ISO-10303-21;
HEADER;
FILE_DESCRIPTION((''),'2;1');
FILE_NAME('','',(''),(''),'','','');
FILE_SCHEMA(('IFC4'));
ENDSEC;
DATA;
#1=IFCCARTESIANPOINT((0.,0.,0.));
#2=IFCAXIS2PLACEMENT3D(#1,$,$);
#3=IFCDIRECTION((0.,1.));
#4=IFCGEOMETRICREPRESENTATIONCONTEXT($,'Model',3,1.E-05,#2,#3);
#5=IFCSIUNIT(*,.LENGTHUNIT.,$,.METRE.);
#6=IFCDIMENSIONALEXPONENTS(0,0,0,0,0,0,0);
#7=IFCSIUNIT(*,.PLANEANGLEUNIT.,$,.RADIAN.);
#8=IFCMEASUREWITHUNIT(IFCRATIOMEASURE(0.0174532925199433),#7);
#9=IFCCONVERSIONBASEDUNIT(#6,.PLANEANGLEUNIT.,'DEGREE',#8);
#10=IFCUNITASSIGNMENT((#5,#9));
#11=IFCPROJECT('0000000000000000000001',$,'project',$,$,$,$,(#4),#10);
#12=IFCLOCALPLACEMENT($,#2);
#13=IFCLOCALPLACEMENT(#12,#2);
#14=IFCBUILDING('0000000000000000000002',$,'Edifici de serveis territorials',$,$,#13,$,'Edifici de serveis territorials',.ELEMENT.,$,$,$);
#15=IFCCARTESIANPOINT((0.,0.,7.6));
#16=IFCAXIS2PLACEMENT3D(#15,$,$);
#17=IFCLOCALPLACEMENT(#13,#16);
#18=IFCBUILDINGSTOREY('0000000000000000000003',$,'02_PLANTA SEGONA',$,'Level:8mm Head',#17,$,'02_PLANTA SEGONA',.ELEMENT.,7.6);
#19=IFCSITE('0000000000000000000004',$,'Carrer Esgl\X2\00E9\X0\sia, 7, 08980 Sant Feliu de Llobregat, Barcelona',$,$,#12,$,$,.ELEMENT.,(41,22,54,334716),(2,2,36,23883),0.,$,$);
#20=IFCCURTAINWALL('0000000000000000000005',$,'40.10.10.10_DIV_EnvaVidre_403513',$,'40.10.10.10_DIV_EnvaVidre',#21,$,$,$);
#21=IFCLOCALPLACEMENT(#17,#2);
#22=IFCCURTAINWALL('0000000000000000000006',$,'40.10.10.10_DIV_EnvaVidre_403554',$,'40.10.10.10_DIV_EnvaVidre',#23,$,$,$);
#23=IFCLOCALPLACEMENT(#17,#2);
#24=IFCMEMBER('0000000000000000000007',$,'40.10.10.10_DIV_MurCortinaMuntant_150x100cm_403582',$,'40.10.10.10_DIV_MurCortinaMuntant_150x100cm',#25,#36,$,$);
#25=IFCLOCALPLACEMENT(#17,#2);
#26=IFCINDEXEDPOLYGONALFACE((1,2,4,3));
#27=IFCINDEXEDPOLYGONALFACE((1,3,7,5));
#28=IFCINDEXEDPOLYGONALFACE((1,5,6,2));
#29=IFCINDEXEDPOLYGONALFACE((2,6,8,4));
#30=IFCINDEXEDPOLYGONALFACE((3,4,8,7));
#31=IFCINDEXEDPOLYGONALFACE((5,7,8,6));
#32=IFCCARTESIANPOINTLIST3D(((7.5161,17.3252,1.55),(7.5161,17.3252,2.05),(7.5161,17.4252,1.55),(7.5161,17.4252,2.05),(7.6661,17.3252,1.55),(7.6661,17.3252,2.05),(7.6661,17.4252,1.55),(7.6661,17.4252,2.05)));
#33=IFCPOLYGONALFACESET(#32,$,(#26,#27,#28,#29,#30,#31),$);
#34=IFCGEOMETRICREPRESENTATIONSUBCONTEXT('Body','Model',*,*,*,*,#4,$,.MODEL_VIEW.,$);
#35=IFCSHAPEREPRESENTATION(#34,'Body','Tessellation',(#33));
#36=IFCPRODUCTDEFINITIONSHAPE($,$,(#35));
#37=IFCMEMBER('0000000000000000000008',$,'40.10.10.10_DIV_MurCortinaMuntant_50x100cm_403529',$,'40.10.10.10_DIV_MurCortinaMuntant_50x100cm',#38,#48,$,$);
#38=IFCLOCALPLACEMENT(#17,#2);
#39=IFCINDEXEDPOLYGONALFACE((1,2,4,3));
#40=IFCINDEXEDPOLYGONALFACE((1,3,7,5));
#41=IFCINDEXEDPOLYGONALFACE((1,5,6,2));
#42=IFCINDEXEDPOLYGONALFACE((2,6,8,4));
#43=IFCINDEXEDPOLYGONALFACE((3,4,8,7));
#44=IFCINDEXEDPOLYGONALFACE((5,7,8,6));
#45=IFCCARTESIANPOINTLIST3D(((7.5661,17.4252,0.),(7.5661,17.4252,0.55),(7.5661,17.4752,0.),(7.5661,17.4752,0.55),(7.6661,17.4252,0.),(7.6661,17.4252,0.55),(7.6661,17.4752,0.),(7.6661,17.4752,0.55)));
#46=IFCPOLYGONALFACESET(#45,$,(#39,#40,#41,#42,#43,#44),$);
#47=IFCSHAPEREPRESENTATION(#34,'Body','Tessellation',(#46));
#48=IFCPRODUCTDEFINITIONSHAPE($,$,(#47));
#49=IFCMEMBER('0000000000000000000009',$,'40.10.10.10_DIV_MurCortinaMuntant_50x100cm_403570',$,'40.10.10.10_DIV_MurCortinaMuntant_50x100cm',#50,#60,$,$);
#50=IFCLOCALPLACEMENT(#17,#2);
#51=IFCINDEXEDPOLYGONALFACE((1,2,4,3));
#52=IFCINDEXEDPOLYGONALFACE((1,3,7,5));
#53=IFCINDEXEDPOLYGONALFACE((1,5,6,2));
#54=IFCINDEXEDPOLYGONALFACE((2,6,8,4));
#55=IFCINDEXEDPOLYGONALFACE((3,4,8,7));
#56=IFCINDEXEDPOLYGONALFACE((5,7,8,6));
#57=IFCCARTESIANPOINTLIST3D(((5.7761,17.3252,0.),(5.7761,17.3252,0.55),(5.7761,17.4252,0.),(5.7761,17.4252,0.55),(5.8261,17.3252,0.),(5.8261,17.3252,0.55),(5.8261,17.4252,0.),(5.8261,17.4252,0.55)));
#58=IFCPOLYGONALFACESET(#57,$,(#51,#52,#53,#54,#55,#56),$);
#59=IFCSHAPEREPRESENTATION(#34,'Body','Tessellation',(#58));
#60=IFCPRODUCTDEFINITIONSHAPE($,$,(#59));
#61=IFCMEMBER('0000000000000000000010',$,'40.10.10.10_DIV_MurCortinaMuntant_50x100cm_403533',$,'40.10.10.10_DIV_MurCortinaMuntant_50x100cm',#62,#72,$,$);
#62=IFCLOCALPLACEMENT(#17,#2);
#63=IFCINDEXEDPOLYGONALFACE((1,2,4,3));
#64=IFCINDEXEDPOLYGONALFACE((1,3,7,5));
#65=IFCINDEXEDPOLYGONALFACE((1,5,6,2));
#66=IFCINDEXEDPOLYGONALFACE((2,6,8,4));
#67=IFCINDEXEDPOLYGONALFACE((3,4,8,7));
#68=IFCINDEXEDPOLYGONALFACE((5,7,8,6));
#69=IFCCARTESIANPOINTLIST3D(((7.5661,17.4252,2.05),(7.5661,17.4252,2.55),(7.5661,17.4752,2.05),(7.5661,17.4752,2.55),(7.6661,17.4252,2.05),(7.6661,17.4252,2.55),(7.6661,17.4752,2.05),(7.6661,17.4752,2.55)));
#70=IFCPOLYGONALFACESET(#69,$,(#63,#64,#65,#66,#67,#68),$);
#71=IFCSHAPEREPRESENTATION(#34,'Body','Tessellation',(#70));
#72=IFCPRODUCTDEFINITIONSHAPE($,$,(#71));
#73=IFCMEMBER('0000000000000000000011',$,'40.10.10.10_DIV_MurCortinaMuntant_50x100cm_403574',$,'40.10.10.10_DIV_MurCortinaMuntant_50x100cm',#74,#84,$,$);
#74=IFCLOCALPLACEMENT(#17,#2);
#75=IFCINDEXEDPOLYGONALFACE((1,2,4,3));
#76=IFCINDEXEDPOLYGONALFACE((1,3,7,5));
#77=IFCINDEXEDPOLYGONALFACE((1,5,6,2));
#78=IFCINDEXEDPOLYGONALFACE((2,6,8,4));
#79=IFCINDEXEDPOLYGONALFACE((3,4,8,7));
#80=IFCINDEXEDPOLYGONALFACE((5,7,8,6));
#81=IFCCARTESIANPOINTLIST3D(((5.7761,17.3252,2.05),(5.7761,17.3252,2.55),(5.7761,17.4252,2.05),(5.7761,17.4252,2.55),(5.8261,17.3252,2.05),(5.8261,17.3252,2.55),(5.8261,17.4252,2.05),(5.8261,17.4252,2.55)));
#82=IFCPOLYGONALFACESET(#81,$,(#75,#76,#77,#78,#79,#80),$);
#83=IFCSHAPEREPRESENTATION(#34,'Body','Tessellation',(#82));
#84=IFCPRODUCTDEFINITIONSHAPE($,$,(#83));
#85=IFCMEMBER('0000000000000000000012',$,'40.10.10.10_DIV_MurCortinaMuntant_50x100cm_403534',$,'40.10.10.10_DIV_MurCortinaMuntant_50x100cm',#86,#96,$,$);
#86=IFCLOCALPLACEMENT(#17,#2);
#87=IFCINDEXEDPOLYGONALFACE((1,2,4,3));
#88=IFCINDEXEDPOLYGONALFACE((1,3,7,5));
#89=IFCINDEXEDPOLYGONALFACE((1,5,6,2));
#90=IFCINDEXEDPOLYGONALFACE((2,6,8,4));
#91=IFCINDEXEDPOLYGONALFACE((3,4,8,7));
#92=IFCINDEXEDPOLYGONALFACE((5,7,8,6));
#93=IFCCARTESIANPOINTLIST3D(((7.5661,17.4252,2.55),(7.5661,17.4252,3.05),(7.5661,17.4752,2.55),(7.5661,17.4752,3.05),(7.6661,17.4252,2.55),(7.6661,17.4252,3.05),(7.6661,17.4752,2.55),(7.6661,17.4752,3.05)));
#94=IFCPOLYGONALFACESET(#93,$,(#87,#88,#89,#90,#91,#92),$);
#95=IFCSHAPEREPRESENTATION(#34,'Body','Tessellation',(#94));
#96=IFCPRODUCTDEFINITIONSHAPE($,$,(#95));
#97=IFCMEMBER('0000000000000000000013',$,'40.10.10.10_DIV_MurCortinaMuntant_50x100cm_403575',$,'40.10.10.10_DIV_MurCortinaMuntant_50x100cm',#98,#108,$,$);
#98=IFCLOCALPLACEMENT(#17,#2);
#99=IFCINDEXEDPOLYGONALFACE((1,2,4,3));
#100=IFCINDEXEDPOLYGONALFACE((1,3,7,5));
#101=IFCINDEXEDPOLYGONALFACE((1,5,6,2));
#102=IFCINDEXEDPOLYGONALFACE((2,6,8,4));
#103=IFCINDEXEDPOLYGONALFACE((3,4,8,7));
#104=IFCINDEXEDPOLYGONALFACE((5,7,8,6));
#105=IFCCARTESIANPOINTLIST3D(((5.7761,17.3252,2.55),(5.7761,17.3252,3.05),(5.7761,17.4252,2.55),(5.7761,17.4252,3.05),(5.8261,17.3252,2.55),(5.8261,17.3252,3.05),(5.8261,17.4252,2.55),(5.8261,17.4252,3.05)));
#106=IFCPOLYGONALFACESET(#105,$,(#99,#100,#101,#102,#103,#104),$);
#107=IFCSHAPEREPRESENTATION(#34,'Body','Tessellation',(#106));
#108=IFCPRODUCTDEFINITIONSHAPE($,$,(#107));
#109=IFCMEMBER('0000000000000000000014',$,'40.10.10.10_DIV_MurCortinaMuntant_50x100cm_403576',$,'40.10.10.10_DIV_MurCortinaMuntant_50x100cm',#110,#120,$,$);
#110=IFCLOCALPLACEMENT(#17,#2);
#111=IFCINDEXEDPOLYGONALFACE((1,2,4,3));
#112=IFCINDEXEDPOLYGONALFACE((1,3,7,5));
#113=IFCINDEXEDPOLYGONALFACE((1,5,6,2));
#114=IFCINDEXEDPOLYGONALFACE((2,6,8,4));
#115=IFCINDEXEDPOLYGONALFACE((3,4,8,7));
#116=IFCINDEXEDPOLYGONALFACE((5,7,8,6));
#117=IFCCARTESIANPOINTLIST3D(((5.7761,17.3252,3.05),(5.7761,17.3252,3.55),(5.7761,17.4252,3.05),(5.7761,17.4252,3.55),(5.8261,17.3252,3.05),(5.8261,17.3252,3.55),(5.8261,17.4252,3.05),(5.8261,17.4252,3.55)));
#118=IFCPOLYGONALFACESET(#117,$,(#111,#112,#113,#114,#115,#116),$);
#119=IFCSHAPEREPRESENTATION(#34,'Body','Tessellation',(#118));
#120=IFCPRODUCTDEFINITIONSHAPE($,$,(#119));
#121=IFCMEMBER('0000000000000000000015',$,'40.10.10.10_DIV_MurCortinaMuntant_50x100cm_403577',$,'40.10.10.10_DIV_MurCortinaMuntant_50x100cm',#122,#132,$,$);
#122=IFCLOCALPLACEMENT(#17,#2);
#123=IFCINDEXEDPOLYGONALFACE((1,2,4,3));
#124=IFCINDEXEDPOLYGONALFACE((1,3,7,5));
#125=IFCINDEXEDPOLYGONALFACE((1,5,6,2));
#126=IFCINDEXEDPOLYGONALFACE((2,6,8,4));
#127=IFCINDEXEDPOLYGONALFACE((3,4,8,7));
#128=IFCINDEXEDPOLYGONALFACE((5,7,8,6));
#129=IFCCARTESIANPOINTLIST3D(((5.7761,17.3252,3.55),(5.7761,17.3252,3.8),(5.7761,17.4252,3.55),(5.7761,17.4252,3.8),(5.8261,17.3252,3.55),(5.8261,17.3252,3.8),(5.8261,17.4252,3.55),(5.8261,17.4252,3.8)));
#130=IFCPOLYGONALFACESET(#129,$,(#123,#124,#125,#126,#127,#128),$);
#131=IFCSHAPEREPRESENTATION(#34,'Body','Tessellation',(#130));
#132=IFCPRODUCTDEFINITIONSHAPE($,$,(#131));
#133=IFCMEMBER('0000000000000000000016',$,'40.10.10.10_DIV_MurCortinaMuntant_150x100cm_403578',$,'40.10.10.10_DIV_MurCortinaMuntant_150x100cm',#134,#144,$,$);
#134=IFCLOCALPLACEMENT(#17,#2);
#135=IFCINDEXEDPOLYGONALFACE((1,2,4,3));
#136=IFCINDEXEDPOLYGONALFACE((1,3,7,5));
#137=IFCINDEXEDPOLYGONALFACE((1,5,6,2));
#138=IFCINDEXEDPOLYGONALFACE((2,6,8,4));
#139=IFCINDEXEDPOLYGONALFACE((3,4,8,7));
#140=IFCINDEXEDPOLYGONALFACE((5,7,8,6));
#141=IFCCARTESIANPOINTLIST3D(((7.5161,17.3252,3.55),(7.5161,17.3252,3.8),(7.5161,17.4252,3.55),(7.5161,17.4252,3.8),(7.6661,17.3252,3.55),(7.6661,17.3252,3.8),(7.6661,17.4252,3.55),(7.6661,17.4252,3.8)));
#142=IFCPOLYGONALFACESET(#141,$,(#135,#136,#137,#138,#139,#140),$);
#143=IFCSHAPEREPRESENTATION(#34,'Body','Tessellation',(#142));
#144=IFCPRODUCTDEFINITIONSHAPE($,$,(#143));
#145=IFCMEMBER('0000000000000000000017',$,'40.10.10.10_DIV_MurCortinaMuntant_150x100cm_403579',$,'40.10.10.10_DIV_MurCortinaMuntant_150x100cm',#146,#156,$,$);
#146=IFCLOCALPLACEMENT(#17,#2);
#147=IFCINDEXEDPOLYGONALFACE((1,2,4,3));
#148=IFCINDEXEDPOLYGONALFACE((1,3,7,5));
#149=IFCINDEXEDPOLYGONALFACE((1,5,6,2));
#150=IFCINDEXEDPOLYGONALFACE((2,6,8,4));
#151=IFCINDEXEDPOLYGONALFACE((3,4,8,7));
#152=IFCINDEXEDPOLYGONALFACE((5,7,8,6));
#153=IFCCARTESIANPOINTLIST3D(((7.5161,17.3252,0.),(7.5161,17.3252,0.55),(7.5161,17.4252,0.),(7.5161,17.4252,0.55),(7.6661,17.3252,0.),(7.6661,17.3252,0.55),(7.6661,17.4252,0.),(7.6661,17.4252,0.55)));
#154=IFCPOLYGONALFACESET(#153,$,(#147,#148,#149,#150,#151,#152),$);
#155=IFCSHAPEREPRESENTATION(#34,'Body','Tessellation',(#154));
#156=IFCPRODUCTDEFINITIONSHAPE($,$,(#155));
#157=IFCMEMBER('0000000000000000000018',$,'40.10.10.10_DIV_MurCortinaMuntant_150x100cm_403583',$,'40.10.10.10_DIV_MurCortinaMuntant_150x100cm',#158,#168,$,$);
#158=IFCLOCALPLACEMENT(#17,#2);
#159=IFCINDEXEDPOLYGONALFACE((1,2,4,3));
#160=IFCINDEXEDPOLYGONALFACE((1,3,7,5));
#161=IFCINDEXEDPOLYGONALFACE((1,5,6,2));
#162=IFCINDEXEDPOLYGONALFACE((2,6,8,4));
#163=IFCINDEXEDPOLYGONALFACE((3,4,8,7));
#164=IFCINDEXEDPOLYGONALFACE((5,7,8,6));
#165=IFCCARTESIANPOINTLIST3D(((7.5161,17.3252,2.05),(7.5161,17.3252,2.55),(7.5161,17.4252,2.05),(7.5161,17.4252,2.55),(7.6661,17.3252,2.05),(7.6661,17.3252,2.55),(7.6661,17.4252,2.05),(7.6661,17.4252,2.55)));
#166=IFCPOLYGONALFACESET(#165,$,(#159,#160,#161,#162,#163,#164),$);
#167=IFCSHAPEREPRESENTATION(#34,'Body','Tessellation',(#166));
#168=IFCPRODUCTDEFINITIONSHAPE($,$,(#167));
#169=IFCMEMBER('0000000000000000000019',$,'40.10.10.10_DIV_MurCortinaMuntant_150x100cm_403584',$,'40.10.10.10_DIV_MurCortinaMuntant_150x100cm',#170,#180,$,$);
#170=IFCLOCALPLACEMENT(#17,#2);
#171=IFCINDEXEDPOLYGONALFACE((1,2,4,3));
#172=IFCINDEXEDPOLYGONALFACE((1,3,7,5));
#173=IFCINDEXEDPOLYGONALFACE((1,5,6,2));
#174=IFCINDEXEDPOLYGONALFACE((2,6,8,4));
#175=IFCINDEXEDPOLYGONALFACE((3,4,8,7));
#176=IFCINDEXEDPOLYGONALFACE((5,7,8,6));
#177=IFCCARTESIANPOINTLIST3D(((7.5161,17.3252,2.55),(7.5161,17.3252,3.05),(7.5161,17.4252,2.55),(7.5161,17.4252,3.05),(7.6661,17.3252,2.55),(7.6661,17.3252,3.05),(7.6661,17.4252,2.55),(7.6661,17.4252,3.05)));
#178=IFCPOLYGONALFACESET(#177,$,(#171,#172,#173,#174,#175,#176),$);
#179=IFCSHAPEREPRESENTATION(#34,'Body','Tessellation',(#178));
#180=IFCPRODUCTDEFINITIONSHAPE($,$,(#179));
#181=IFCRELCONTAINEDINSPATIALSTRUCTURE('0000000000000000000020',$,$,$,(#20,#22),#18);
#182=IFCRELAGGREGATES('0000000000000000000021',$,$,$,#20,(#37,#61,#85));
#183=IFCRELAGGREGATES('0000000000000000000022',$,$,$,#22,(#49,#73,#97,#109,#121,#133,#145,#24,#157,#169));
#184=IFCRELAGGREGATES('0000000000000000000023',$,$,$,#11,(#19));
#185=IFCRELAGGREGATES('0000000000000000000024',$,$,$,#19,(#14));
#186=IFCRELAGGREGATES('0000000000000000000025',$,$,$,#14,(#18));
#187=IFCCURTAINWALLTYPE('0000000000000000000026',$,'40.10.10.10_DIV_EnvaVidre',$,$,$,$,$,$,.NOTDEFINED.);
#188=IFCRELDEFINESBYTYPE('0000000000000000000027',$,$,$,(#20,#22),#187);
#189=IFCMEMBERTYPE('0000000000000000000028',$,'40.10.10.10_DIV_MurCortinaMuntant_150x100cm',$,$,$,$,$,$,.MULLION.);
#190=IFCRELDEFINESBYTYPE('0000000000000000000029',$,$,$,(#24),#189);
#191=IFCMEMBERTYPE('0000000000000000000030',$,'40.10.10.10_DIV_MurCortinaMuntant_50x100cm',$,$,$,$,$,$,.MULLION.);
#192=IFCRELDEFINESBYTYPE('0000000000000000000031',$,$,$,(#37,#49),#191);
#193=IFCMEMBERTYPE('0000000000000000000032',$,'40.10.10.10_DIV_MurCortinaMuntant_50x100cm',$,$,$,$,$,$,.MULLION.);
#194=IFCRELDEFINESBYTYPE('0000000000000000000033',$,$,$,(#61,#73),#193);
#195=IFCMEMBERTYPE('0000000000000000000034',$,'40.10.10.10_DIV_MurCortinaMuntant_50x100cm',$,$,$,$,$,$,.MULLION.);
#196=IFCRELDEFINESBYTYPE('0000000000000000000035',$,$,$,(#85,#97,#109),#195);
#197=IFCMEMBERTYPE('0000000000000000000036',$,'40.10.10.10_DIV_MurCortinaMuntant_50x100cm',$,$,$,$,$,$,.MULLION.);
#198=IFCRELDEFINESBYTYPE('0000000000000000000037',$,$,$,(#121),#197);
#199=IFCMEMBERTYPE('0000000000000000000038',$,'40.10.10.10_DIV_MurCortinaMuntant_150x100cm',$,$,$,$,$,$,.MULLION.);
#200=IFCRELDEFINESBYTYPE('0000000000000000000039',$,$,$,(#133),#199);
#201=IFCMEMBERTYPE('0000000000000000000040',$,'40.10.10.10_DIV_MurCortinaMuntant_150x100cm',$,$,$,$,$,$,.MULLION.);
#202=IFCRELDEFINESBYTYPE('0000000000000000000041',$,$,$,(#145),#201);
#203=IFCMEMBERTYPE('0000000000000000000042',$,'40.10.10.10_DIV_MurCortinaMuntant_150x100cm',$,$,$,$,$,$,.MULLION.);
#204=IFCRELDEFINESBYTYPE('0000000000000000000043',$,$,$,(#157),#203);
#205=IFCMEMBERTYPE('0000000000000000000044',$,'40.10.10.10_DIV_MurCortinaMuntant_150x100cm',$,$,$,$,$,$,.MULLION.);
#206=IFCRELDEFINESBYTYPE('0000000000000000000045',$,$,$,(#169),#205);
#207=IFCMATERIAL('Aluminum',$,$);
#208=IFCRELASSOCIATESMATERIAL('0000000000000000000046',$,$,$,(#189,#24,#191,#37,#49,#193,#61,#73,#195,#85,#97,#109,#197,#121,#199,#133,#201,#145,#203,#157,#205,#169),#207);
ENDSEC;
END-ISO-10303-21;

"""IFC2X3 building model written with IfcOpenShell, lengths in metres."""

from ifc_helpers import new_model, entity, si_unit, converted_unit, direction, frame, origin, origin_2d_with_axis, place, context, subcontext, project, spatial, rectangle, extrude, source, transform, mapped, material, type_object, type_shapes, element, aggregate, save


model = new_model("IFC2X3")

# Units and contexts
model_context = context("Model", 3, precision=1e-05, world=origin(), true_north=direction((0.0, 1.0)))
body_context = subcontext(model_context, "Body", "Model", "MODEL_VIEW")
ifc_project = project(units=[si_unit("LENGTHUNIT", "METRE"), converted_unit("PLANEANGLEUNIT", "DEGREE", entity("IfcRatioMeasure", 0.0174532925199433), si_unit("PLANEANGLEUNIT", "RADIAN"), dimensions=[0, 0, 0, 0, 0, 0, 0])], contexts=[model_context])

# Site, building, storey
site_placement = place(None, origin())
site = spatial("IfcSite", under=ifc_project, at=site_placement, Name="Carrer Església, 7, 08980 Sant Feliu de Llobregat, Barcelona", CompositionType="ELEMENT", RefLatitude=(41, 22, 54, 334716), RefLongitude=(2, 2, 36, 23883), RefElevation=0.0)
building_placement = place(site_placement, origin())
building = spatial("IfcBuilding", under=site, at=building_placement, Name="Edifici de serveis territorials", LongName="Edifici de serveis territorials", CompositionType="ELEMENT")
storey_placement = place(building_placement, frame((0.0, 0.0, 7.6)))
storey = spatial("IfcBuildingStorey", under=building, at=storey_placement, Name="02_PLANTA SEGONA", ObjectType="Level:8mm Head", LongName="02_PLANTA SEGONA", CompositionType="ELEMENT", Elevation=7.6)

# Curtain walls, member
curtain_wall_type = type_object("IfcCurtainWallType", Name="40.10.10.10_DIV_EnvaVidre", PredefinedType="NOTDEFINED")
curtain_wall_1_placement = place(storey_placement, frame((0.0, 0.0, -7.6)))
curtain_wall_1 = element("IfcCurtainWall", 1, at=curtain_wall_1_placement, inside=storey, type_object=curtain_wall_type, Name="40.10.10.10_DIV_EnvaVidre_403513", ObjectType="40.10.10.10_DIV_EnvaVidre")
ifc_material_1 = material(Name="Aluminum")
curtain_wall_2_placement = place(storey_placement, frame((0.0, 0.0, -7.6)))
curtain_wall_2 = element("IfcCurtainWall", 2, at=curtain_wall_2_placement, inside=storey, type_object=curtain_wall_type, Name="40.10.10.10_DIV_EnvaVidre_403554", ObjectType="40.10.10.10_DIV_EnvaVidre")
member_type_1 = type_object("IfcMemberType", Name="40.10.10.10_DIV_MurCortinaMuntant_150x100cm", PredefinedType="MULLION", material=ifc_material_1)
shared_shape_1 = source(origin(), body_context, "Body", "SweptSolid", [
    extrude(rectangle(XDim=0.1, YDim=0.15, at=origin_2d_with_axis()), frame((-0.075, 0.0, -0.5), z_axis=(0.0, 0.0, 1.0), x_axis=(0.0, -1.0, 0.0)), (0.0, 0.0, 1.0), 0.5),
])
type_shapes(member_type_1, [shared_shape_1])
member_1_placement = place(storey_placement, frame((7.6661, 17.3752, 2.05)))
member_1 = element("IfcMember", 3, at=member_1_placement, type_object=member_type_1, material=ifc_material_1, Name="40.10.10.10_DIV_MurCortinaMuntant_150x100cm_403582", ObjectType="40.10.10.10_DIV_MurCortinaMuntant_150x100cm", context=body_context, shape_type="MappedRepresentation", body=[
    mapped(shared_shape_1, transform((0.0, 0.0, 0.0), scale=1.0)),
])

# Members
member_type_2 = type_object("IfcMemberType", Name="40.10.10.10_DIV_MurCortinaMuntant_50x100cm", PredefinedType="MULLION", material=ifc_material_1)
shared_shape_2 = source(origin(), body_context, "Body", "SweptSolid", [
    extrude(rectangle(XDim=0.1, YDim=0.05, at=origin_2d_with_axis()), frame((-0.025, 0.0, -0.55), z_axis=(0.0, 0.0, 1.0), x_axis=(0.0, -1.0, 0.0)), (0.0, 0.0, 1.0), 0.55),
])
type_shapes(member_type_2, [shared_shape_2])
member_2_placement = place(storey_placement, frame((7.6161, 17.4252, 0.0), z_axis=(0.0, 0.0, -1.0), x_axis=(0.0, -1.0, 0.0)))
member_2 = element("IfcMember", 4, at=member_2_placement, type_object=member_type_2, material=ifc_material_1, Name="40.10.10.10_DIV_MurCortinaMuntant_50x100cm_403529", ObjectType="40.10.10.10_DIV_MurCortinaMuntant_50x100cm", context=body_context, shape_type="MappedRepresentation", body=[
    mapped(shared_shape_2, transform((0.0, 0.0, 0.0), scale=1.0)),
])
member_3_placement = place(storey_placement, frame((5.7761, 17.3752, 0.0), z_axis=(0.0, 0.0, -1.0), x_axis=(-1.0, 0.0, 0.0)))
member_3 = element("IfcMember", 5, at=member_3_placement, type_object=member_type_2, material=ifc_material_1, Name="40.10.10.10_DIV_MurCortinaMuntant_50x100cm_403570", ObjectType="40.10.10.10_DIV_MurCortinaMuntant_50x100cm", context=body_context, shape_type="MappedRepresentation", body=[
    mapped(shared_shape_2, transform((0.0, 0.0, 0.0), scale=1.0)),
])
member_type_3 = type_object("IfcMemberType", Name="40.10.10.10_DIV_MurCortinaMuntant_50x100cm", PredefinedType="MULLION", material=ifc_material_1)
shared_shape_3 = source(origin(), body_context, "Body", "SweptSolid", [
    extrude(rectangle(XDim=0.1, YDim=0.05, at=origin_2d_with_axis()), frame((-0.025, 0.0, -0.5), z_axis=(0.0, 0.0, 1.0), x_axis=(0.0, -1.0, 0.0)), (0.0, 0.0, 1.0), 0.5),
])
type_shapes(member_type_3, [shared_shape_3])
member_4_placement = place(storey_placement, frame((7.6161, 17.4252, 2.05), z_axis=(0.0, 0.0, -1.0), x_axis=(0.0, -1.0, 0.0)))
member_4 = element("IfcMember", 6, at=member_4_placement, type_object=member_type_3, material=ifc_material_1, Name="40.10.10.10_DIV_MurCortinaMuntant_50x100cm_403533", ObjectType="40.10.10.10_DIV_MurCortinaMuntant_50x100cm", context=body_context, shape_type="MappedRepresentation", body=[
    mapped(shared_shape_3, transform((0.0, 0.0, 0.0), scale=1.0)),
])
member_5_placement = place(storey_placement, frame((5.7761, 17.3752, 2.05), z_axis=(0.0, 0.0, -1.0), x_axis=(-1.0, 0.0, 0.0)))
member_5 = element("IfcMember", 7, at=member_5_placement, type_object=member_type_3, material=ifc_material_1, Name="40.10.10.10_DIV_MurCortinaMuntant_50x100cm_403574", ObjectType="40.10.10.10_DIV_MurCortinaMuntant_50x100cm", context=body_context, shape_type="MappedRepresentation", body=[
    mapped(shared_shape_3, transform((0.0, 0.0, 0.0), scale=1.0)),
])
member_type_4 = type_object("IfcMemberType", Name="40.10.10.10_DIV_MurCortinaMuntant_50x100cm", PredefinedType="MULLION", material=ifc_material_1)
shared_shape_4 = source(origin(), body_context, "Body", "SweptSolid", [
    extrude(rectangle(XDim=0.1, YDim=0.05, at=origin_2d_with_axis()), frame((-0.025, 0.0, -0.5), z_axis=(0.0, 0.0, 1.0), x_axis=(0.0, -1.0, 0.0)), (0.0, 0.0, 1.0), 0.5),
])
type_shapes(member_type_4, [shared_shape_4])
member_6_placement = place(storey_placement, frame((7.6161, 17.4252, 2.55), z_axis=(0.0, 0.0, -1.0), x_axis=(0.0, -1.0, 0.0)))
member_6 = element("IfcMember", 8, at=member_6_placement, type_object=member_type_4, material=ifc_material_1, Name="40.10.10.10_DIV_MurCortinaMuntant_50x100cm_403534", ObjectType="40.10.10.10_DIV_MurCortinaMuntant_50x100cm", context=body_context, shape_type="MappedRepresentation", body=[
    mapped(shared_shape_4, transform((0.0, 0.0, 0.0), scale=1.0)),
])
aggregate(curtain_wall_1, [member_2, member_4, member_6])
member_7_placement = place(storey_placement, frame((5.7761, 17.3752, 2.55), z_axis=(0.0, 0.0, -1.0), x_axis=(-1.0, 0.0, 0.0)))
member_7 = element("IfcMember", 9, at=member_7_placement, type_object=member_type_4, material=ifc_material_1, Name="40.10.10.10_DIV_MurCortinaMuntant_50x100cm_403575", ObjectType="40.10.10.10_DIV_MurCortinaMuntant_50x100cm", context=body_context, shape_type="MappedRepresentation", body=[
    mapped(shared_shape_4, transform((0.0, 0.0, 0.0), scale=1.0)),
])
member_8_placement = place(storey_placement, frame((5.7761, 17.3752, 3.05), z_axis=(0.0, 0.0, -1.0), x_axis=(-1.0, 0.0, 0.0)))
member_8 = element("IfcMember", 10, at=member_8_placement, type_object=member_type_4, material=ifc_material_1, Name="40.10.10.10_DIV_MurCortinaMuntant_50x100cm_403576", ObjectType="40.10.10.10_DIV_MurCortinaMuntant_50x100cm", context=body_context, shape_type="MappedRepresentation", body=[
    mapped(shared_shape_4, transform((0.0, 0.0, 0.0), scale=1.0)),
])
member_type_5 = type_object("IfcMemberType", Name="40.10.10.10_DIV_MurCortinaMuntant_50x100cm", PredefinedType="MULLION", material=ifc_material_1)
shared_shape_5 = source(origin(), body_context, "Body", "SweptSolid", [
    extrude(rectangle(XDim=0.1, YDim=0.05, at=origin_2d_with_axis()), frame((-0.025, 0.0, -0.25), z_axis=(0.0, 0.0, 1.0), x_axis=(0.0, -1.0, 0.0)), (0.0, 0.0, 1.0), 0.25),
])
type_shapes(member_type_5, [shared_shape_5])
member_9_placement = place(storey_placement, frame((5.7761, 17.3752, 3.55), z_axis=(0.0, 0.0, -1.0), x_axis=(-1.0, 0.0, 0.0)))
member_9 = element("IfcMember", 11, at=member_9_placement, type_object=member_type_5, material=ifc_material_1, Name="40.10.10.10_DIV_MurCortinaMuntant_50x100cm_403577", ObjectType="40.10.10.10_DIV_MurCortinaMuntant_50x100cm", context=body_context, shape_type="MappedRepresentation", body=[
    mapped(shared_shape_5, transform((0.0, 0.0, 0.0), scale=1.0)),
])
member_type_6 = type_object("IfcMemberType", Name="40.10.10.10_DIV_MurCortinaMuntant_150x100cm", PredefinedType="MULLION", material=ifc_material_1)
shared_shape_6 = source(origin(), body_context, "Body", "SweptSolid", [
    extrude(rectangle(XDim=0.1, YDim=0.15, at=origin_2d_with_axis()), frame((-0.075, 0.0, -0.25), z_axis=(0.0, 0.0, 1.0), x_axis=(0.0, -1.0, 0.0)), (0.0, 0.0, 1.0), 0.25),
])
type_shapes(member_type_6, [shared_shape_6])
member_10_placement = place(storey_placement, frame((7.6661, 17.3752, 3.8)))
member_10 = element("IfcMember", 12, at=member_10_placement, type_object=member_type_6, material=ifc_material_1, Name="40.10.10.10_DIV_MurCortinaMuntant_150x100cm_403578", ObjectType="40.10.10.10_DIV_MurCortinaMuntant_150x100cm", context=body_context, shape_type="MappedRepresentation", body=[
    mapped(shared_shape_6, transform((0.0, 0.0, 0.0), scale=1.0)),
])
member_type_7 = type_object("IfcMemberType", Name="40.10.10.10_DIV_MurCortinaMuntant_150x100cm", PredefinedType="MULLION", material=ifc_material_1)
shared_shape_7 = source(origin(), body_context, "Body", "SweptSolid", [
    extrude(rectangle(XDim=0.1, YDim=0.15, at=origin_2d_with_axis()), frame((-0.075, 0.0, -0.55), z_axis=(0.0, 0.0, 1.0), x_axis=(0.0, -1.0, 0.0)), (0.0, 0.0, 1.0), 0.55),
])
type_shapes(member_type_7, [shared_shape_7])
member_11_placement = place(storey_placement, frame((7.6661, 17.3752, 0.55)))
member_11 = element("IfcMember", 13, at=member_11_placement, type_object=member_type_7, material=ifc_material_1, Name="40.10.10.10_DIV_MurCortinaMuntant_150x100cm_403579", ObjectType="40.10.10.10_DIV_MurCortinaMuntant_150x100cm", context=body_context, shape_type="MappedRepresentation", body=[
    mapped(shared_shape_7, transform((0.0, 0.0, 0.0), scale=1.0)),
])
member_type_8 = type_object("IfcMemberType", Name="40.10.10.10_DIV_MurCortinaMuntant_150x100cm", PredefinedType="MULLION", material=ifc_material_1)
shared_shape_8 = source(origin(), body_context, "Body", "SweptSolid", [
    extrude(rectangle(XDim=0.1, YDim=0.15, at=origin_2d_with_axis()), frame((-0.075, 0.0, -0.5), z_axis=(0.0, 0.0, 1.0), x_axis=(0.0, -1.0, 0.0)), (0.0, 0.0, 1.0), 0.5),
])
type_shapes(member_type_8, [shared_shape_8])
member_12_placement = place(storey_placement, frame((7.6661, 17.3752, 2.55)))
member_12 = element("IfcMember", 14, at=member_12_placement, type_object=member_type_8, material=ifc_material_1, Name="40.10.10.10_DIV_MurCortinaMuntant_150x100cm_403583", ObjectType="40.10.10.10_DIV_MurCortinaMuntant_150x100cm", context=body_context, shape_type="MappedRepresentation", body=[
    mapped(shared_shape_8, transform((0.0, 0.0, 0.0), scale=1.0)),
])
member_type_9 = type_object("IfcMemberType", Name="40.10.10.10_DIV_MurCortinaMuntant_150x100cm", PredefinedType="MULLION", material=ifc_material_1)
shared_shape_9 = source(origin(), body_context, "Body", "SweptSolid", [
    extrude(rectangle(XDim=0.1, YDim=0.15, at=origin_2d_with_axis()), frame((-0.075, 0.0, -0.5), z_axis=(0.0, 0.0, 1.0), x_axis=(0.0, -1.0, 0.0)), (0.0, 0.0, 1.0), 0.5),
])
type_shapes(member_type_9, [shared_shape_9])
member_13_placement = place(storey_placement, frame((7.6661, 17.3752, 3.05)))
member_13 = element("IfcMember", 15, at=member_13_placement, type_object=member_type_9, material=ifc_material_1, Name="40.10.10.10_DIV_MurCortinaMuntant_150x100cm_403584", ObjectType="40.10.10.10_DIV_MurCortinaMuntant_150x100cm", context=body_context, shape_type="MappedRepresentation", body=[
    mapped(shared_shape_9, transform((0.0, 0.0, 0.0), scale=1.0)),
])

aggregate(curtain_wall_2, [member_3, member_5, member_7, member_8, member_9, member_10, member_11, member_1, member_12, member_13])

save(model, "model.ifc")
